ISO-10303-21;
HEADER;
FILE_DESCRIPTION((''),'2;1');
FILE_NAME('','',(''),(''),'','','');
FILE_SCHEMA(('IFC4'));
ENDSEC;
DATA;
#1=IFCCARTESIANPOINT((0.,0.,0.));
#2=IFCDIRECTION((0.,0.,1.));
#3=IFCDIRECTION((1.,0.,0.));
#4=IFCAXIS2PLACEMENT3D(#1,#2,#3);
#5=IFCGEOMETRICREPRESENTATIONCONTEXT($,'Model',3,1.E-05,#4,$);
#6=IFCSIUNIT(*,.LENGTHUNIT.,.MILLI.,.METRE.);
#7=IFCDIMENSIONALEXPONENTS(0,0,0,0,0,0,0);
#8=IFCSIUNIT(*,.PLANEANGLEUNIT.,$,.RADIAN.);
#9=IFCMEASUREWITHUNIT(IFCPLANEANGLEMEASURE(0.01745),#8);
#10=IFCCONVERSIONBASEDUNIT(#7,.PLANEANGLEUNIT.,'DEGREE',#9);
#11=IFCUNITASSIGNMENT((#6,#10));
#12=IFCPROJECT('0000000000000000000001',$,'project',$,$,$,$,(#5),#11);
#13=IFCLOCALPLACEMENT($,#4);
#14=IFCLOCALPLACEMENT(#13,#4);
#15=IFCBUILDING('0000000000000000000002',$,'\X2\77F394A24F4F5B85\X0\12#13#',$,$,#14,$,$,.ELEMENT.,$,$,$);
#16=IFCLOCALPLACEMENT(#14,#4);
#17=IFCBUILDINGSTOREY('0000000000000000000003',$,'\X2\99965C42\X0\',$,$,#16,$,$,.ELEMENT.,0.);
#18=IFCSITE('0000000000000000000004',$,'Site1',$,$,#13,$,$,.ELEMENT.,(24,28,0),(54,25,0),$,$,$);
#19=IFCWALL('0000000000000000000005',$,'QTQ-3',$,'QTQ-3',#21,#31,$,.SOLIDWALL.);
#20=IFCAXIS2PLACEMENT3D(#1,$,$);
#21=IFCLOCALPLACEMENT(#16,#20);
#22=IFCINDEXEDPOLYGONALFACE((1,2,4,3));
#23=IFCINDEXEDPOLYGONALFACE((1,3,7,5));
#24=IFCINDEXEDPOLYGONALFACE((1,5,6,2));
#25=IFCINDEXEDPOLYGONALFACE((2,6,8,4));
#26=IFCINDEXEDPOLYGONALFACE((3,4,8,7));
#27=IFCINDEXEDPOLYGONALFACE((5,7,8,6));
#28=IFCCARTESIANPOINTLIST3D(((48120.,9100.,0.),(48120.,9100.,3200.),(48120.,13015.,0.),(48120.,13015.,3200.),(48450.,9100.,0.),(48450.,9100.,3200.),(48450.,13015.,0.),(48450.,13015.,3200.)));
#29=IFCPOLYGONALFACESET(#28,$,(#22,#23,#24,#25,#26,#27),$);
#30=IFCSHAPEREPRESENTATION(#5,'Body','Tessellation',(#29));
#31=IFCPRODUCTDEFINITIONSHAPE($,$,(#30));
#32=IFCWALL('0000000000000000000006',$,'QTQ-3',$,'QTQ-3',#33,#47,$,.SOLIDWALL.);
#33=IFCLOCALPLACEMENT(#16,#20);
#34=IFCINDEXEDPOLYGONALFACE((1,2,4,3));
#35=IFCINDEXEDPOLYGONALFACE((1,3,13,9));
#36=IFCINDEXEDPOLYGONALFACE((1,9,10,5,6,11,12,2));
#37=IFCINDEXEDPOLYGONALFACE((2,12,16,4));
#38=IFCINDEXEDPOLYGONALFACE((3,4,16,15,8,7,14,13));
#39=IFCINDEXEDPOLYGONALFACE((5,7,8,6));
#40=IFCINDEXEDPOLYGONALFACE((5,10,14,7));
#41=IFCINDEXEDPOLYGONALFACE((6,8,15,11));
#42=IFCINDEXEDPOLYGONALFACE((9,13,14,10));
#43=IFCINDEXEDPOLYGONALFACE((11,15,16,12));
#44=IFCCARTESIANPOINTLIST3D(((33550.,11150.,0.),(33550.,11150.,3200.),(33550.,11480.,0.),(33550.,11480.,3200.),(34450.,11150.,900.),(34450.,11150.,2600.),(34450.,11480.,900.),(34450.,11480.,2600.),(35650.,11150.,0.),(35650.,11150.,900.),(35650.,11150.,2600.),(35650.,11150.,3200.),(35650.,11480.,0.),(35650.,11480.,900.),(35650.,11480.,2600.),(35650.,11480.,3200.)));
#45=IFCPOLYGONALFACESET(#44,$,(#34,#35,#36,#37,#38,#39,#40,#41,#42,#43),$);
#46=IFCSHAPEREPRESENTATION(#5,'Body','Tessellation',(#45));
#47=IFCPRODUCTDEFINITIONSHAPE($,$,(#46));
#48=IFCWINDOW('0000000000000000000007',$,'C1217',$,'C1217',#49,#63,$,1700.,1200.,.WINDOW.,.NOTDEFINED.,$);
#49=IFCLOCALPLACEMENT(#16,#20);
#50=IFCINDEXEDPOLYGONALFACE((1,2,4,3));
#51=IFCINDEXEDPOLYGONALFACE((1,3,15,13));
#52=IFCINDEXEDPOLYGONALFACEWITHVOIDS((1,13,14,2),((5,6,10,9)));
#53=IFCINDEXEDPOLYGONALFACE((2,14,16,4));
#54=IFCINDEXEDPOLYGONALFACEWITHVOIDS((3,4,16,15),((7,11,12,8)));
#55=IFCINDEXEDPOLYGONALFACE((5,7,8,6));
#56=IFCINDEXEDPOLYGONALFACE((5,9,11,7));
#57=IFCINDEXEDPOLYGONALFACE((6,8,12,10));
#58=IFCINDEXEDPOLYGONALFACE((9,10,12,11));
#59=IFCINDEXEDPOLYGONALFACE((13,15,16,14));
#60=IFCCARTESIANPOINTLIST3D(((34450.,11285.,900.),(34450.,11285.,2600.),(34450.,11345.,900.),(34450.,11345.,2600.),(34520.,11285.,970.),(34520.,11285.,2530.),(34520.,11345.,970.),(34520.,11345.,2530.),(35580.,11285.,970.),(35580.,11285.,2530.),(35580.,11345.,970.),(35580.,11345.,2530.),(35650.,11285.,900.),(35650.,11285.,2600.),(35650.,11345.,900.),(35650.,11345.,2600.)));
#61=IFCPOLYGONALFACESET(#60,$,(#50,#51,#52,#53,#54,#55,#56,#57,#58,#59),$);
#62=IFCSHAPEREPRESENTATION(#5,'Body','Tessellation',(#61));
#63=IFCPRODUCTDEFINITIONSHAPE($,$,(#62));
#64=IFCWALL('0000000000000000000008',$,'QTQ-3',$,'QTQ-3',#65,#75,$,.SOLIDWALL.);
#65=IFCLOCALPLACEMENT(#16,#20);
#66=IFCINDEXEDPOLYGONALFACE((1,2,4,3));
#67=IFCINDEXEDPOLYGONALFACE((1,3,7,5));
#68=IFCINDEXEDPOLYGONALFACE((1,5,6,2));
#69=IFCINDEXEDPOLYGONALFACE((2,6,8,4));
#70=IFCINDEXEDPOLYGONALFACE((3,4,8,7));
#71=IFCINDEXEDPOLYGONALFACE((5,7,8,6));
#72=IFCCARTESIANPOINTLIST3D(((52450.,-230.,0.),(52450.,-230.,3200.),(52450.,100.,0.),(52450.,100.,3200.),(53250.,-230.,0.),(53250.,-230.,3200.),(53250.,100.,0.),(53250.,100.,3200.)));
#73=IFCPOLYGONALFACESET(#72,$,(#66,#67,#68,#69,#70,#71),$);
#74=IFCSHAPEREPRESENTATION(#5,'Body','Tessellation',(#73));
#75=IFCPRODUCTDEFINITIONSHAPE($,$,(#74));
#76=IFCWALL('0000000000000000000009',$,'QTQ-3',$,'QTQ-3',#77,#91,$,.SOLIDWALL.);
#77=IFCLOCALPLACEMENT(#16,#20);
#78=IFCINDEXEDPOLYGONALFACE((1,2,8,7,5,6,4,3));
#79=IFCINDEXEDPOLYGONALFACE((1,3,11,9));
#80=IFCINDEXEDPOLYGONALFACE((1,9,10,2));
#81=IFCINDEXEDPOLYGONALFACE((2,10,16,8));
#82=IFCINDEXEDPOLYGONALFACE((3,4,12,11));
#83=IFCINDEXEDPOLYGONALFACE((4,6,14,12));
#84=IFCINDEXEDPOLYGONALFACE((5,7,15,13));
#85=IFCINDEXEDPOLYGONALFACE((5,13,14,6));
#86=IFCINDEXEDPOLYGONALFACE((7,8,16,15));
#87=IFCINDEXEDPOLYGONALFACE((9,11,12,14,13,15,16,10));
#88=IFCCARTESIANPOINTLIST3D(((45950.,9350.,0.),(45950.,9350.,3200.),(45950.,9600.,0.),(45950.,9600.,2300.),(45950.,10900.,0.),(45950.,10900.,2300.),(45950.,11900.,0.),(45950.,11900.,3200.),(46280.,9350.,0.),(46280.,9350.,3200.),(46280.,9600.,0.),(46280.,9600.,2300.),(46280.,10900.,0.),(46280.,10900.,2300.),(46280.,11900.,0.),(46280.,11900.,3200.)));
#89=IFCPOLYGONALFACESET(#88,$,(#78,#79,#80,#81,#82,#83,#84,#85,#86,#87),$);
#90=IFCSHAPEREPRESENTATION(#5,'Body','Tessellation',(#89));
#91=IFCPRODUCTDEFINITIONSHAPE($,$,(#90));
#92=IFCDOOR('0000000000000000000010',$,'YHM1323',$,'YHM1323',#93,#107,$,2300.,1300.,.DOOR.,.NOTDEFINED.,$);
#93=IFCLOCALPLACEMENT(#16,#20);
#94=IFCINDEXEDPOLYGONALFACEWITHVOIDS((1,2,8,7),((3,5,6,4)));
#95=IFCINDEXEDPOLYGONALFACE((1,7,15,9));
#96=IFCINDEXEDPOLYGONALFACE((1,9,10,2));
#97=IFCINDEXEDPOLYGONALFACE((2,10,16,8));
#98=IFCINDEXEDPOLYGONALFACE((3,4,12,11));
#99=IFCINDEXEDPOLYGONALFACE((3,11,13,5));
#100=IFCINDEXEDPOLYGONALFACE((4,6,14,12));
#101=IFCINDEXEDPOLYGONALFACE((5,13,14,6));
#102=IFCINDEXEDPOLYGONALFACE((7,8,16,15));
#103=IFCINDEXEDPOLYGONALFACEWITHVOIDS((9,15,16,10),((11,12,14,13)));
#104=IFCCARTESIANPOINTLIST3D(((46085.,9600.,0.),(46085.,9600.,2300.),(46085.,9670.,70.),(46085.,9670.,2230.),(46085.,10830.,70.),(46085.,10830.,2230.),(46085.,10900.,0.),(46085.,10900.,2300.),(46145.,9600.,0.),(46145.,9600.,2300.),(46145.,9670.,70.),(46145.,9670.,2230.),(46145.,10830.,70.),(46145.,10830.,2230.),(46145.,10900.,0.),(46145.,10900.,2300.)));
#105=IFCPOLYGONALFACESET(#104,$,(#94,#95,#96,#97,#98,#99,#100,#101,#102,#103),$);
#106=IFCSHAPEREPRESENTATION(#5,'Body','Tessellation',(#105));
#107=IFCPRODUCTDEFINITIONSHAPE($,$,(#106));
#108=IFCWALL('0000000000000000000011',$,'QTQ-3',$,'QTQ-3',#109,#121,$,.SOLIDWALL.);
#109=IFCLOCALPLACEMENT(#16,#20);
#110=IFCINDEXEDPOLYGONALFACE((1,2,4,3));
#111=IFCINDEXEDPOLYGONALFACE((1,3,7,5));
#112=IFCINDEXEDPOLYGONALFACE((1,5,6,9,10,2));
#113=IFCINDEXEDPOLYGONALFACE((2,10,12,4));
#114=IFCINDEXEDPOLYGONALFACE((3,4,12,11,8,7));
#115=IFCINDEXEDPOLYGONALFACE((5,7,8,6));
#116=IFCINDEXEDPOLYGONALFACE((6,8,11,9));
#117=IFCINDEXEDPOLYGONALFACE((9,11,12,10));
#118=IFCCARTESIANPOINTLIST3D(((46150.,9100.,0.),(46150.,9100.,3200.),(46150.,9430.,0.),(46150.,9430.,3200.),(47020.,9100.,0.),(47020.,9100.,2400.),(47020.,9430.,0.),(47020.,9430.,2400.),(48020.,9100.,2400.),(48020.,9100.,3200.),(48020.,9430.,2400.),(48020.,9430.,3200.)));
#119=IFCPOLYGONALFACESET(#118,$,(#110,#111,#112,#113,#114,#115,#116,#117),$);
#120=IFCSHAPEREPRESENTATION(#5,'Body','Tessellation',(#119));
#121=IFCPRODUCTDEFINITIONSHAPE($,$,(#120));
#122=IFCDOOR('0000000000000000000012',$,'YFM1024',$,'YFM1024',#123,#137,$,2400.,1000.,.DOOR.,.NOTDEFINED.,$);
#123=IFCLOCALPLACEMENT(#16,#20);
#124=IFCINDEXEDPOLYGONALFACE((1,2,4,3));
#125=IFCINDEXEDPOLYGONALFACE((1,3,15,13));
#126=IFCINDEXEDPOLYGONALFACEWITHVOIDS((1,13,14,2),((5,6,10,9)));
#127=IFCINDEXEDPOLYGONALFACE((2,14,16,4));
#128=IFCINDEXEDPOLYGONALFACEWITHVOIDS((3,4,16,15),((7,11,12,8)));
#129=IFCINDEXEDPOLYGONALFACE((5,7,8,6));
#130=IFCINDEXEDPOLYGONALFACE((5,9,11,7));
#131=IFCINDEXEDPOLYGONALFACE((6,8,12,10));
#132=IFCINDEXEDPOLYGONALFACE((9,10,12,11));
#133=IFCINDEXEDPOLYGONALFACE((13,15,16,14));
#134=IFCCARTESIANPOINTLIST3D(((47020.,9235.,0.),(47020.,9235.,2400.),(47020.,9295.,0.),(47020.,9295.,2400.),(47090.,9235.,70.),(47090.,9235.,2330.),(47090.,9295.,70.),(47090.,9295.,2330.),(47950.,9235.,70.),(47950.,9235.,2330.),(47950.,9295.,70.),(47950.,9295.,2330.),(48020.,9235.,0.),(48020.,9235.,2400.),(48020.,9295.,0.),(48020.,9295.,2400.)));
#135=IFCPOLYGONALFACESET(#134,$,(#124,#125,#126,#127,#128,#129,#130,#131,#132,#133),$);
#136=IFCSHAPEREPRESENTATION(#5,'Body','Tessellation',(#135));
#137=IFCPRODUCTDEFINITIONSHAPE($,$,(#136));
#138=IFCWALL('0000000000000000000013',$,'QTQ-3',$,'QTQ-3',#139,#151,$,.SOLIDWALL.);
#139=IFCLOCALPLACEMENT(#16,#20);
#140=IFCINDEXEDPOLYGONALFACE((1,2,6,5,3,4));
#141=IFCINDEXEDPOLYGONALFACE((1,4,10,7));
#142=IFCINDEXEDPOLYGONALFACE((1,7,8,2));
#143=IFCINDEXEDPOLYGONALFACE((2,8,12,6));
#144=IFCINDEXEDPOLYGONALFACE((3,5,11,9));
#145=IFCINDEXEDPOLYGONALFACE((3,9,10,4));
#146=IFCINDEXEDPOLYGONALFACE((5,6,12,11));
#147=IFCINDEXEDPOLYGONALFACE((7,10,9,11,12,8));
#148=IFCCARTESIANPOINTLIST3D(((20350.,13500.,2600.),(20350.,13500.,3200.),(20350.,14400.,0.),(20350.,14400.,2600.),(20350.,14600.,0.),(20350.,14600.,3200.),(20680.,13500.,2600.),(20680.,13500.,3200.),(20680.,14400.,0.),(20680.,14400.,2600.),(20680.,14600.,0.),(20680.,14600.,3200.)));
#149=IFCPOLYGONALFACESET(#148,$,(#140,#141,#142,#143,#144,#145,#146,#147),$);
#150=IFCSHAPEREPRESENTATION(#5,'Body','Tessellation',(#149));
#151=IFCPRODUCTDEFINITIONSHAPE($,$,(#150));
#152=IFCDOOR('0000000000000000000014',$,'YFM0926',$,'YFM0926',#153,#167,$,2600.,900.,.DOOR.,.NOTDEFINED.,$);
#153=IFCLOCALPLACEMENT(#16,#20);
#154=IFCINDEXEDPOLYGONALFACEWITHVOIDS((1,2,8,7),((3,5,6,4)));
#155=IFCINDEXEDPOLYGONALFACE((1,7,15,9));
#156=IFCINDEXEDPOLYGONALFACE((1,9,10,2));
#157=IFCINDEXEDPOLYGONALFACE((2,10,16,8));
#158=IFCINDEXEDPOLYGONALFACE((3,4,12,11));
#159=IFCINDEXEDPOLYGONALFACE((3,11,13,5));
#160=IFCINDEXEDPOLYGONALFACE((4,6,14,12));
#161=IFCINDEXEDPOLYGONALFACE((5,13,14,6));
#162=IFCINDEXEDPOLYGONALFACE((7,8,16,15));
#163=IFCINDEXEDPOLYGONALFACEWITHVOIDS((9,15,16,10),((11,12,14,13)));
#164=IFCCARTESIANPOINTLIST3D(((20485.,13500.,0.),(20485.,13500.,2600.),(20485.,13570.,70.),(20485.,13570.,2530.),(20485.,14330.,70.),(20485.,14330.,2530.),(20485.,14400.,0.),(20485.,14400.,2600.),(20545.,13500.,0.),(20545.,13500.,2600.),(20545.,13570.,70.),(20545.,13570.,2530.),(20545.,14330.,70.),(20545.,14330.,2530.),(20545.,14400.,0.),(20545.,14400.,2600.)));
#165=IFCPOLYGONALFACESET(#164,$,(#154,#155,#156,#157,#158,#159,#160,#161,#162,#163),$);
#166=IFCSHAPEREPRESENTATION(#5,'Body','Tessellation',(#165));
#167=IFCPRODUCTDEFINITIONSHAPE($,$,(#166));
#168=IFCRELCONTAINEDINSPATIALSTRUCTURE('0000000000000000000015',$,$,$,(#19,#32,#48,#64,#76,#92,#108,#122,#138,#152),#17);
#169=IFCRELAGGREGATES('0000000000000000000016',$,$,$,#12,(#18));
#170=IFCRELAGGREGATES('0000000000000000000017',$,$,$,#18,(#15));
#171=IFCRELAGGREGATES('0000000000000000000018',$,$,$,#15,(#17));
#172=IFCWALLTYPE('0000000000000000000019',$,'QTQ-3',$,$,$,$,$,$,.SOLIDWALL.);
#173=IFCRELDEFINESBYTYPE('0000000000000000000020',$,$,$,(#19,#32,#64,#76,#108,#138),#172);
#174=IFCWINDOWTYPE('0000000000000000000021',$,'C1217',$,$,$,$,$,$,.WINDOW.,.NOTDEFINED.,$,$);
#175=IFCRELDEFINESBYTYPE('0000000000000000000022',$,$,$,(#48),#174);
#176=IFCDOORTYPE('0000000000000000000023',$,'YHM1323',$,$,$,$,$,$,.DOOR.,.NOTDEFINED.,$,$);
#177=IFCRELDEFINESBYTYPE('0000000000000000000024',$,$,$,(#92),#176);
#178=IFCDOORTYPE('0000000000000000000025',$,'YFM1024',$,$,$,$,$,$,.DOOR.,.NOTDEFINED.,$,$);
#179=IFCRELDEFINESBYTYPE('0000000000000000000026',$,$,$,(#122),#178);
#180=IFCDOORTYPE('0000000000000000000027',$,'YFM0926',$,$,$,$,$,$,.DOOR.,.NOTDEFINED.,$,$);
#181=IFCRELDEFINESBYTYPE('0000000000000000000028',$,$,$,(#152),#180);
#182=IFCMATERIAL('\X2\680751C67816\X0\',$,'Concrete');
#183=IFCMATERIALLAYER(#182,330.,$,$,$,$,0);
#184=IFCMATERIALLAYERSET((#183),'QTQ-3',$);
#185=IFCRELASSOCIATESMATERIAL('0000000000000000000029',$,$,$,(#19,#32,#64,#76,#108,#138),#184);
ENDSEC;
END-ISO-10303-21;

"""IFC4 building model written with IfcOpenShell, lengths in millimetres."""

from ifc_helpers import new_model, entity, si_unit, converted_unit, frame, origin_with_axes, place, context, project, spatial, polyline, outline, extrude, material, layer, layer_set, type_object, element, fill, save


model = new_model("IFC4")

# Units and contexts
model_context = context("Model", 3, precision=1e-05, world=origin_with_axes())
ifc_project = project(units=[si_unit("LENGTHUNIT", "METRE", prefix="MILLI"), converted_unit("PLANEANGLEUNIT", "DEGREE", entity("IfcPlaneAngleMeasure", 0.01745), si_unit("PLANEANGLEUNIT", "RADIAN"), dimensions=[0, 0, 0, 0, 0, 0, 0])], contexts=[model_context])

# Site, building, storey
site_placement = place(None, origin_with_axes())
site = spatial("IfcSite", under=ifc_project, at=site_placement, Name="Site1", CompositionType="ELEMENT", RefLatitude=(24, 28, 0), RefLongitude=(54, 25, 0))
building_placement = place(site_placement, origin_with_axes())
building = spatial("IfcBuilding", under=site, at=building_placement, Name="石钢住宅12#13#", CompositionType="ELEMENT")
storey_placement = place(building_placement, origin_with_axes())
storey = spatial("IfcBuildingStorey", under=building, at=storey_placement, Name="首层", CompositionType="ELEMENT", Elevation=0.0)

# Wall
ifc_material = material(Name="标准砖", Category="Concrete")
ifc_layer = layer(ifc_material, 330.0, Priority=0)
ifc_layer_set = layer_set([ifc_layer], Name="QTQ-3")
wall_type = type_object("IfcWallType", Name="QTQ-3", PredefinedType="SOLIDWALL")
wall_1_placement = place(storey_placement, origin_with_axes())
element("IfcWall", 1, at=wall_1_placement, inside=storey, type_object=wall_type, material=ifc_layer_set, Name="QTQ-3", ObjectType="QTQ-3", PredefinedType="SOLIDWALL", context=model_context, shape_type="SweptSolid", body=[
    extrude(outline(polyline([(0.0, 0.0), (3200.0, 0.0), (3200.0, 3915.0), (0.0, 3915.0), (0.0, 0.0)])), frame((48120.0, 9100.0, 3200.0), z_axis=(1.0, 0.0, 0.0), x_axis=(0.0, 0.0, -1.0)), (0.0, 0.0, 1.0), 330.0),
])

# Wall, opening, window
wall_2_placement = place(storey_placement, origin_with_axes())
wall_2 = element("IfcWall", 2, at=wall_2_placement, inside=storey, type_object=wall_type, material=ifc_layer_set, Name="QTQ-3", ObjectType="QTQ-3", PredefinedType="SOLIDWALL", context=model_context, shape_type="SweptSolid", body=[
    extrude(outline(polyline([(0.0, 0.0), (3200.0, 0.0), (3200.0, 2100.0), (0.0, 2100.0), (0.0, 0.0)])), frame((35650.0, 11150.0, 3200.0), z_axis=(0.0, 1.0, 0.0), x_axis=(0.0, 0.0, -1.0)), (0.0, 0.0, 1.0), 330.0),
])
opening_1_placement = place(storey_placement, origin_with_axes())
opening_1 = element("IfcOpeningElement", 3, at=opening_1_placement, cuts=wall_2, PredefinedType="OPENING", context=model_context, shape_type="SweptSolid", body=[
    extrude(outline(polyline([(0.0, 0.0), (1200.0, 0.0), (1200.0, 1700.0), (0.0, 1700.0), (0.0, 0.0)])), frame((35650.0, 10150.0, 900.0), z_axis=(0.0, 1.0, 0.0), x_axis=(-1.0, 0.0, 0.0)), (0.0, 0.0, 1.0), 2330.0),
])
window_type_1 = type_object("IfcWindowType", Name="C1217", PartitioningType="NOTDEFINED", PredefinedType="WINDOW")
window_1_placement = place(storey_placement, origin_with_axes())
window_1 = element("IfcWindow", 4, at=window_1_placement, inside=storey, type_object=window_type_1, Name="C1217", ObjectType="C1217", OverallHeight=1700.0, OverallWidth=1200.0, PartitioningType="NOTDEFINED", PredefinedType="WINDOW", context=model_context, shape_type="SweptSolid", body=[
    extrude(outline(polyline([(-600.0, -850.0), (600.0, -850.0), (600.0, 850.0), (-600.0, 850.0), (-600.0, -850.0)]), holes=[polyline([(-530.0, -780.0), (-530.0, 780.0), (530.0, 780.0), (530.0, -780.0), (-530.0, -780.0)])]), frame((35050.0, 11285.0, 1750.0), z_axis=(0.0, 1.0, 0.0), x_axis=(-1.0, 0.0, 0.0)), (0.0, 0.0, 1.0), 60.0),
])
fill(opening_1, window_1)

# Wall
wall_3_placement = place(storey_placement, origin_with_axes())
element("IfcWall", 5, at=wall_3_placement, inside=storey, type_object=wall_type, material=ifc_layer_set, Name="QTQ-3", ObjectType="QTQ-3", PredefinedType="SOLIDWALL", context=model_context, shape_type="SweptSolid", body=[
    extrude(outline(polyline([(0.0, 0.0), (3200.0, 0.0), (3200.0, 800.0), (0.0, 800.0), (0.0, 0.0)])), frame((53250.0, -230.0, 3200.0), z_axis=(0.0, 1.0, 0.0), x_axis=(0.0, 0.0, -1.0)), (0.0, 0.0, 1.0), 330.0),
])

# Walls, openings, doors
wall_4_placement = place(storey_placement, origin_with_axes())
wall_4 = element("IfcWall", 6, at=wall_4_placement, inside=storey, type_object=wall_type, material=ifc_layer_set, Name="QTQ-3", ObjectType="QTQ-3", PredefinedType="SOLIDWALL", context=model_context, shape_type="SweptSolid", body=[
    extrude(outline(polyline([(0.0, 0.0), (3200.0, 0.0), (3200.0, 2550.0), (0.0, 2550.0), (0.0, 0.0)])), frame((45950.0, 9350.0, 3200.0), z_axis=(1.0, 0.0, 0.0), x_axis=(0.0, 0.0, -1.0)), (0.0, 0.0, 1.0), 330.0),
])
opening_2_placement = place(storey_placement, origin_with_axes())
opening_2 = element("IfcOpeningElement", 7, at=opening_2_placement, cuts=wall_4, PredefinedType="OPENING", context=model_context, shape_type="SweptSolid", body=[
    extrude(outline(polyline([(0.0, 0.0), (1300.0, 0.0), (1300.0, 2300.0), (0.0, 2300.0), (0.0, 0.0)])), frame((44950.0, 9600.0, 0.0), z_axis=(1.0, 0.0, 0.0), x_axis=(0.0, 1.0, 0.0)), (0.0, 0.0, 1.0), 2330.0),
])
door_type_1 = type_object("IfcDoorType", Name="YHM1323", OperationType="NOTDEFINED", PredefinedType="DOOR")
door_1_placement = place(storey_placement, origin_with_axes())
door_1 = element("IfcDoor", 8, at=door_1_placement, inside=storey, type_object=door_type_1, Name="YHM1323", ObjectType="YHM1323", OperationType="NOTDEFINED", OverallHeight=2300.0, OverallWidth=1300.0, PredefinedType="DOOR", context=model_context, shape_type="SweptSolid", body=[
    extrude(outline(polyline([(-650.0, -1150.0), (650.0, -1150.0), (650.0, 1150.0), (-650.0, 1150.0), (-650.0, -1150.0)]), holes=[polyline([(-580.0, -1080.0), (-580.0, 1080.0), (580.0, 1080.0), (580.0, -1080.0), (-580.0, -1080.0)])]), frame((46085.0, 10250.0, 1150.0), z_axis=(1.0, 0.0, 0.0), x_axis=(0.0, 1.0, 0.0)), (0.0, 0.0, 1.0), 60.0),
])
fill(opening_2, door_1)
wall_5_placement = place(storey_placement, origin_with_axes())
wall_5 = element("IfcWall", 9, at=wall_5_placement, inside=storey, type_object=wall_type, material=ifc_layer_set, Name="QTQ-3", ObjectType="QTQ-3", PredefinedType="SOLIDWALL", context=model_context, shape_type="SweptSolid", body=[
    extrude(outline(polyline([(0.0, 0.0), (3200.0, 0.0), (3200.0, 1870.0), (0.0, 1870.0), (0.0, 0.0)])), frame((48020.0, 9100.0, 3200.0), z_axis=(0.0, 1.0, 0.0), x_axis=(0.0, 0.0, -1.0)), (0.0, 0.0, 1.0), 330.0),
])
opening_3_placement = place(storey_placement, origin_with_axes())
opening_3 = element("IfcOpeningElement", 10, at=opening_3_placement, cuts=wall_5, PredefinedType="OPENING", context=model_context, shape_type="SweptSolid", body=[
    extrude(outline(polyline([(0.0, 0.0), (1000.0, 0.0), (1000.0, 2400.0), (0.0, 2400.0), (0.0, 0.0)])), frame((48020.0, 8100.0, 0.0), z_axis=(0.0, 1.0, 0.0), x_axis=(-1.0, 0.0, 0.0)), (0.0, 0.0, 1.0), 2330.0),
])
door_type_2 = type_object("IfcDoorType", Name="YFM1024", OperationType="NOTDEFINED", PredefinedType="DOOR")
door_2_placement = place(storey_placement, origin_with_axes())
door_2 = element("IfcDoor", 11, at=door_2_placement, inside=storey, type_object=door_type_2, Name="YFM1024", ObjectType="YFM1024", OperationType="NOTDEFINED", OverallHeight=2400.0, OverallWidth=1000.0, PredefinedType="DOOR", context=model_context, shape_type="SweptSolid", body=[
    extrude(outline(polyline([(-500.0, -1200.0), (500.0, -1200.0), (500.0, 1200.0), (-500.0, 1200.0), (-500.0, -1200.0)]), holes=[polyline([(-430.0, -1130.0), (-430.0, 1130.0), (430.0, 1130.0), (430.0, -1130.0), (-430.0, -1130.0)])]), frame((47520.0, 9235.0, 1200.0), z_axis=(0.0, 1.0, 0.0), x_axis=(-1.0, 0.0, 0.0)), (0.0, 0.0, 1.0), 60.0),
])
fill(opening_3, door_2)
wall_6_placement = place(storey_placement, origin_with_axes())
wall_6 = element("IfcWall", 12, at=wall_6_placement, inside=storey, type_object=wall_type, material=ifc_layer_set, Name="QTQ-3", ObjectType="QTQ-3", PredefinedType="SOLIDWALL", context=model_context, shape_type="SweptSolid", body=[
    extrude(outline(polyline([(0.0, 0.0), (3200.0, 0.0), (3200.0, 1100.0), (0.0, 1100.0), (0.0, 0.0)])), frame((20680.0, 14600.0, 3200.0), z_axis=(-1.0, 0.0, 0.0), x_axis=(0.0, 0.0, -1.0)), (0.0, 0.0, 1.0), 330.0),
])
opening_4_placement = place(storey_placement, origin_with_axes())
opening_4 = element("IfcOpeningElement", 13, at=opening_4_placement, cuts=wall_6, PredefinedType="OPENING", context=model_context, shape_type="SweptSolid", body=[
    extrude(outline(polyline([(0.0, 0.0), (2600.0, 0.0), (2600.0, 900.0), (0.0, 900.0), (0.0, 0.0)])), frame((21680.0, 13500.0, 0.0), z_axis=(-1.0, 0.0, 0.0), x_axis=(0.0, 0.0, 1.0)), (0.0, 0.0, 1.0), 2330.0),
])
door_type_3 = type_object("IfcDoorType", Name="YFM0926", OperationType="NOTDEFINED", PredefinedType="DOOR")
door_3_placement = place(storey_placement, origin_with_axes())
door_3 = element("IfcDoor", 14, at=door_3_placement, inside=storey, type_object=door_type_3, Name="YFM0926", ObjectType="YFM0926", OperationType="NOTDEFINED", OverallHeight=2600.0, OverallWidth=900.0, PredefinedType="DOOR", context=model_context, shape_type="SweptSolid", body=[
    extrude(outline(polyline([(450.0, -1300.0), (450.0, 1300.0), (-450.0, 1300.0), (-450.0, -1300.0), (450.0, -1300.0)]), holes=[polyline([(380.0, -1230.0), (-380.0, -1230.0), (-380.0, 1230.0), (380.0, 1230.0), (380.0, -1230.0)])]), frame((20545.0, 13950.0, 1300.0), z_axis=(-1.0, 0.0, 0.0), x_axis=(0.0, -1.0, 0.0)), (0.0, 0.0, 1.0), 60.0),
])
fill(opening_4, door_3)

save(model, "model.ifc")
